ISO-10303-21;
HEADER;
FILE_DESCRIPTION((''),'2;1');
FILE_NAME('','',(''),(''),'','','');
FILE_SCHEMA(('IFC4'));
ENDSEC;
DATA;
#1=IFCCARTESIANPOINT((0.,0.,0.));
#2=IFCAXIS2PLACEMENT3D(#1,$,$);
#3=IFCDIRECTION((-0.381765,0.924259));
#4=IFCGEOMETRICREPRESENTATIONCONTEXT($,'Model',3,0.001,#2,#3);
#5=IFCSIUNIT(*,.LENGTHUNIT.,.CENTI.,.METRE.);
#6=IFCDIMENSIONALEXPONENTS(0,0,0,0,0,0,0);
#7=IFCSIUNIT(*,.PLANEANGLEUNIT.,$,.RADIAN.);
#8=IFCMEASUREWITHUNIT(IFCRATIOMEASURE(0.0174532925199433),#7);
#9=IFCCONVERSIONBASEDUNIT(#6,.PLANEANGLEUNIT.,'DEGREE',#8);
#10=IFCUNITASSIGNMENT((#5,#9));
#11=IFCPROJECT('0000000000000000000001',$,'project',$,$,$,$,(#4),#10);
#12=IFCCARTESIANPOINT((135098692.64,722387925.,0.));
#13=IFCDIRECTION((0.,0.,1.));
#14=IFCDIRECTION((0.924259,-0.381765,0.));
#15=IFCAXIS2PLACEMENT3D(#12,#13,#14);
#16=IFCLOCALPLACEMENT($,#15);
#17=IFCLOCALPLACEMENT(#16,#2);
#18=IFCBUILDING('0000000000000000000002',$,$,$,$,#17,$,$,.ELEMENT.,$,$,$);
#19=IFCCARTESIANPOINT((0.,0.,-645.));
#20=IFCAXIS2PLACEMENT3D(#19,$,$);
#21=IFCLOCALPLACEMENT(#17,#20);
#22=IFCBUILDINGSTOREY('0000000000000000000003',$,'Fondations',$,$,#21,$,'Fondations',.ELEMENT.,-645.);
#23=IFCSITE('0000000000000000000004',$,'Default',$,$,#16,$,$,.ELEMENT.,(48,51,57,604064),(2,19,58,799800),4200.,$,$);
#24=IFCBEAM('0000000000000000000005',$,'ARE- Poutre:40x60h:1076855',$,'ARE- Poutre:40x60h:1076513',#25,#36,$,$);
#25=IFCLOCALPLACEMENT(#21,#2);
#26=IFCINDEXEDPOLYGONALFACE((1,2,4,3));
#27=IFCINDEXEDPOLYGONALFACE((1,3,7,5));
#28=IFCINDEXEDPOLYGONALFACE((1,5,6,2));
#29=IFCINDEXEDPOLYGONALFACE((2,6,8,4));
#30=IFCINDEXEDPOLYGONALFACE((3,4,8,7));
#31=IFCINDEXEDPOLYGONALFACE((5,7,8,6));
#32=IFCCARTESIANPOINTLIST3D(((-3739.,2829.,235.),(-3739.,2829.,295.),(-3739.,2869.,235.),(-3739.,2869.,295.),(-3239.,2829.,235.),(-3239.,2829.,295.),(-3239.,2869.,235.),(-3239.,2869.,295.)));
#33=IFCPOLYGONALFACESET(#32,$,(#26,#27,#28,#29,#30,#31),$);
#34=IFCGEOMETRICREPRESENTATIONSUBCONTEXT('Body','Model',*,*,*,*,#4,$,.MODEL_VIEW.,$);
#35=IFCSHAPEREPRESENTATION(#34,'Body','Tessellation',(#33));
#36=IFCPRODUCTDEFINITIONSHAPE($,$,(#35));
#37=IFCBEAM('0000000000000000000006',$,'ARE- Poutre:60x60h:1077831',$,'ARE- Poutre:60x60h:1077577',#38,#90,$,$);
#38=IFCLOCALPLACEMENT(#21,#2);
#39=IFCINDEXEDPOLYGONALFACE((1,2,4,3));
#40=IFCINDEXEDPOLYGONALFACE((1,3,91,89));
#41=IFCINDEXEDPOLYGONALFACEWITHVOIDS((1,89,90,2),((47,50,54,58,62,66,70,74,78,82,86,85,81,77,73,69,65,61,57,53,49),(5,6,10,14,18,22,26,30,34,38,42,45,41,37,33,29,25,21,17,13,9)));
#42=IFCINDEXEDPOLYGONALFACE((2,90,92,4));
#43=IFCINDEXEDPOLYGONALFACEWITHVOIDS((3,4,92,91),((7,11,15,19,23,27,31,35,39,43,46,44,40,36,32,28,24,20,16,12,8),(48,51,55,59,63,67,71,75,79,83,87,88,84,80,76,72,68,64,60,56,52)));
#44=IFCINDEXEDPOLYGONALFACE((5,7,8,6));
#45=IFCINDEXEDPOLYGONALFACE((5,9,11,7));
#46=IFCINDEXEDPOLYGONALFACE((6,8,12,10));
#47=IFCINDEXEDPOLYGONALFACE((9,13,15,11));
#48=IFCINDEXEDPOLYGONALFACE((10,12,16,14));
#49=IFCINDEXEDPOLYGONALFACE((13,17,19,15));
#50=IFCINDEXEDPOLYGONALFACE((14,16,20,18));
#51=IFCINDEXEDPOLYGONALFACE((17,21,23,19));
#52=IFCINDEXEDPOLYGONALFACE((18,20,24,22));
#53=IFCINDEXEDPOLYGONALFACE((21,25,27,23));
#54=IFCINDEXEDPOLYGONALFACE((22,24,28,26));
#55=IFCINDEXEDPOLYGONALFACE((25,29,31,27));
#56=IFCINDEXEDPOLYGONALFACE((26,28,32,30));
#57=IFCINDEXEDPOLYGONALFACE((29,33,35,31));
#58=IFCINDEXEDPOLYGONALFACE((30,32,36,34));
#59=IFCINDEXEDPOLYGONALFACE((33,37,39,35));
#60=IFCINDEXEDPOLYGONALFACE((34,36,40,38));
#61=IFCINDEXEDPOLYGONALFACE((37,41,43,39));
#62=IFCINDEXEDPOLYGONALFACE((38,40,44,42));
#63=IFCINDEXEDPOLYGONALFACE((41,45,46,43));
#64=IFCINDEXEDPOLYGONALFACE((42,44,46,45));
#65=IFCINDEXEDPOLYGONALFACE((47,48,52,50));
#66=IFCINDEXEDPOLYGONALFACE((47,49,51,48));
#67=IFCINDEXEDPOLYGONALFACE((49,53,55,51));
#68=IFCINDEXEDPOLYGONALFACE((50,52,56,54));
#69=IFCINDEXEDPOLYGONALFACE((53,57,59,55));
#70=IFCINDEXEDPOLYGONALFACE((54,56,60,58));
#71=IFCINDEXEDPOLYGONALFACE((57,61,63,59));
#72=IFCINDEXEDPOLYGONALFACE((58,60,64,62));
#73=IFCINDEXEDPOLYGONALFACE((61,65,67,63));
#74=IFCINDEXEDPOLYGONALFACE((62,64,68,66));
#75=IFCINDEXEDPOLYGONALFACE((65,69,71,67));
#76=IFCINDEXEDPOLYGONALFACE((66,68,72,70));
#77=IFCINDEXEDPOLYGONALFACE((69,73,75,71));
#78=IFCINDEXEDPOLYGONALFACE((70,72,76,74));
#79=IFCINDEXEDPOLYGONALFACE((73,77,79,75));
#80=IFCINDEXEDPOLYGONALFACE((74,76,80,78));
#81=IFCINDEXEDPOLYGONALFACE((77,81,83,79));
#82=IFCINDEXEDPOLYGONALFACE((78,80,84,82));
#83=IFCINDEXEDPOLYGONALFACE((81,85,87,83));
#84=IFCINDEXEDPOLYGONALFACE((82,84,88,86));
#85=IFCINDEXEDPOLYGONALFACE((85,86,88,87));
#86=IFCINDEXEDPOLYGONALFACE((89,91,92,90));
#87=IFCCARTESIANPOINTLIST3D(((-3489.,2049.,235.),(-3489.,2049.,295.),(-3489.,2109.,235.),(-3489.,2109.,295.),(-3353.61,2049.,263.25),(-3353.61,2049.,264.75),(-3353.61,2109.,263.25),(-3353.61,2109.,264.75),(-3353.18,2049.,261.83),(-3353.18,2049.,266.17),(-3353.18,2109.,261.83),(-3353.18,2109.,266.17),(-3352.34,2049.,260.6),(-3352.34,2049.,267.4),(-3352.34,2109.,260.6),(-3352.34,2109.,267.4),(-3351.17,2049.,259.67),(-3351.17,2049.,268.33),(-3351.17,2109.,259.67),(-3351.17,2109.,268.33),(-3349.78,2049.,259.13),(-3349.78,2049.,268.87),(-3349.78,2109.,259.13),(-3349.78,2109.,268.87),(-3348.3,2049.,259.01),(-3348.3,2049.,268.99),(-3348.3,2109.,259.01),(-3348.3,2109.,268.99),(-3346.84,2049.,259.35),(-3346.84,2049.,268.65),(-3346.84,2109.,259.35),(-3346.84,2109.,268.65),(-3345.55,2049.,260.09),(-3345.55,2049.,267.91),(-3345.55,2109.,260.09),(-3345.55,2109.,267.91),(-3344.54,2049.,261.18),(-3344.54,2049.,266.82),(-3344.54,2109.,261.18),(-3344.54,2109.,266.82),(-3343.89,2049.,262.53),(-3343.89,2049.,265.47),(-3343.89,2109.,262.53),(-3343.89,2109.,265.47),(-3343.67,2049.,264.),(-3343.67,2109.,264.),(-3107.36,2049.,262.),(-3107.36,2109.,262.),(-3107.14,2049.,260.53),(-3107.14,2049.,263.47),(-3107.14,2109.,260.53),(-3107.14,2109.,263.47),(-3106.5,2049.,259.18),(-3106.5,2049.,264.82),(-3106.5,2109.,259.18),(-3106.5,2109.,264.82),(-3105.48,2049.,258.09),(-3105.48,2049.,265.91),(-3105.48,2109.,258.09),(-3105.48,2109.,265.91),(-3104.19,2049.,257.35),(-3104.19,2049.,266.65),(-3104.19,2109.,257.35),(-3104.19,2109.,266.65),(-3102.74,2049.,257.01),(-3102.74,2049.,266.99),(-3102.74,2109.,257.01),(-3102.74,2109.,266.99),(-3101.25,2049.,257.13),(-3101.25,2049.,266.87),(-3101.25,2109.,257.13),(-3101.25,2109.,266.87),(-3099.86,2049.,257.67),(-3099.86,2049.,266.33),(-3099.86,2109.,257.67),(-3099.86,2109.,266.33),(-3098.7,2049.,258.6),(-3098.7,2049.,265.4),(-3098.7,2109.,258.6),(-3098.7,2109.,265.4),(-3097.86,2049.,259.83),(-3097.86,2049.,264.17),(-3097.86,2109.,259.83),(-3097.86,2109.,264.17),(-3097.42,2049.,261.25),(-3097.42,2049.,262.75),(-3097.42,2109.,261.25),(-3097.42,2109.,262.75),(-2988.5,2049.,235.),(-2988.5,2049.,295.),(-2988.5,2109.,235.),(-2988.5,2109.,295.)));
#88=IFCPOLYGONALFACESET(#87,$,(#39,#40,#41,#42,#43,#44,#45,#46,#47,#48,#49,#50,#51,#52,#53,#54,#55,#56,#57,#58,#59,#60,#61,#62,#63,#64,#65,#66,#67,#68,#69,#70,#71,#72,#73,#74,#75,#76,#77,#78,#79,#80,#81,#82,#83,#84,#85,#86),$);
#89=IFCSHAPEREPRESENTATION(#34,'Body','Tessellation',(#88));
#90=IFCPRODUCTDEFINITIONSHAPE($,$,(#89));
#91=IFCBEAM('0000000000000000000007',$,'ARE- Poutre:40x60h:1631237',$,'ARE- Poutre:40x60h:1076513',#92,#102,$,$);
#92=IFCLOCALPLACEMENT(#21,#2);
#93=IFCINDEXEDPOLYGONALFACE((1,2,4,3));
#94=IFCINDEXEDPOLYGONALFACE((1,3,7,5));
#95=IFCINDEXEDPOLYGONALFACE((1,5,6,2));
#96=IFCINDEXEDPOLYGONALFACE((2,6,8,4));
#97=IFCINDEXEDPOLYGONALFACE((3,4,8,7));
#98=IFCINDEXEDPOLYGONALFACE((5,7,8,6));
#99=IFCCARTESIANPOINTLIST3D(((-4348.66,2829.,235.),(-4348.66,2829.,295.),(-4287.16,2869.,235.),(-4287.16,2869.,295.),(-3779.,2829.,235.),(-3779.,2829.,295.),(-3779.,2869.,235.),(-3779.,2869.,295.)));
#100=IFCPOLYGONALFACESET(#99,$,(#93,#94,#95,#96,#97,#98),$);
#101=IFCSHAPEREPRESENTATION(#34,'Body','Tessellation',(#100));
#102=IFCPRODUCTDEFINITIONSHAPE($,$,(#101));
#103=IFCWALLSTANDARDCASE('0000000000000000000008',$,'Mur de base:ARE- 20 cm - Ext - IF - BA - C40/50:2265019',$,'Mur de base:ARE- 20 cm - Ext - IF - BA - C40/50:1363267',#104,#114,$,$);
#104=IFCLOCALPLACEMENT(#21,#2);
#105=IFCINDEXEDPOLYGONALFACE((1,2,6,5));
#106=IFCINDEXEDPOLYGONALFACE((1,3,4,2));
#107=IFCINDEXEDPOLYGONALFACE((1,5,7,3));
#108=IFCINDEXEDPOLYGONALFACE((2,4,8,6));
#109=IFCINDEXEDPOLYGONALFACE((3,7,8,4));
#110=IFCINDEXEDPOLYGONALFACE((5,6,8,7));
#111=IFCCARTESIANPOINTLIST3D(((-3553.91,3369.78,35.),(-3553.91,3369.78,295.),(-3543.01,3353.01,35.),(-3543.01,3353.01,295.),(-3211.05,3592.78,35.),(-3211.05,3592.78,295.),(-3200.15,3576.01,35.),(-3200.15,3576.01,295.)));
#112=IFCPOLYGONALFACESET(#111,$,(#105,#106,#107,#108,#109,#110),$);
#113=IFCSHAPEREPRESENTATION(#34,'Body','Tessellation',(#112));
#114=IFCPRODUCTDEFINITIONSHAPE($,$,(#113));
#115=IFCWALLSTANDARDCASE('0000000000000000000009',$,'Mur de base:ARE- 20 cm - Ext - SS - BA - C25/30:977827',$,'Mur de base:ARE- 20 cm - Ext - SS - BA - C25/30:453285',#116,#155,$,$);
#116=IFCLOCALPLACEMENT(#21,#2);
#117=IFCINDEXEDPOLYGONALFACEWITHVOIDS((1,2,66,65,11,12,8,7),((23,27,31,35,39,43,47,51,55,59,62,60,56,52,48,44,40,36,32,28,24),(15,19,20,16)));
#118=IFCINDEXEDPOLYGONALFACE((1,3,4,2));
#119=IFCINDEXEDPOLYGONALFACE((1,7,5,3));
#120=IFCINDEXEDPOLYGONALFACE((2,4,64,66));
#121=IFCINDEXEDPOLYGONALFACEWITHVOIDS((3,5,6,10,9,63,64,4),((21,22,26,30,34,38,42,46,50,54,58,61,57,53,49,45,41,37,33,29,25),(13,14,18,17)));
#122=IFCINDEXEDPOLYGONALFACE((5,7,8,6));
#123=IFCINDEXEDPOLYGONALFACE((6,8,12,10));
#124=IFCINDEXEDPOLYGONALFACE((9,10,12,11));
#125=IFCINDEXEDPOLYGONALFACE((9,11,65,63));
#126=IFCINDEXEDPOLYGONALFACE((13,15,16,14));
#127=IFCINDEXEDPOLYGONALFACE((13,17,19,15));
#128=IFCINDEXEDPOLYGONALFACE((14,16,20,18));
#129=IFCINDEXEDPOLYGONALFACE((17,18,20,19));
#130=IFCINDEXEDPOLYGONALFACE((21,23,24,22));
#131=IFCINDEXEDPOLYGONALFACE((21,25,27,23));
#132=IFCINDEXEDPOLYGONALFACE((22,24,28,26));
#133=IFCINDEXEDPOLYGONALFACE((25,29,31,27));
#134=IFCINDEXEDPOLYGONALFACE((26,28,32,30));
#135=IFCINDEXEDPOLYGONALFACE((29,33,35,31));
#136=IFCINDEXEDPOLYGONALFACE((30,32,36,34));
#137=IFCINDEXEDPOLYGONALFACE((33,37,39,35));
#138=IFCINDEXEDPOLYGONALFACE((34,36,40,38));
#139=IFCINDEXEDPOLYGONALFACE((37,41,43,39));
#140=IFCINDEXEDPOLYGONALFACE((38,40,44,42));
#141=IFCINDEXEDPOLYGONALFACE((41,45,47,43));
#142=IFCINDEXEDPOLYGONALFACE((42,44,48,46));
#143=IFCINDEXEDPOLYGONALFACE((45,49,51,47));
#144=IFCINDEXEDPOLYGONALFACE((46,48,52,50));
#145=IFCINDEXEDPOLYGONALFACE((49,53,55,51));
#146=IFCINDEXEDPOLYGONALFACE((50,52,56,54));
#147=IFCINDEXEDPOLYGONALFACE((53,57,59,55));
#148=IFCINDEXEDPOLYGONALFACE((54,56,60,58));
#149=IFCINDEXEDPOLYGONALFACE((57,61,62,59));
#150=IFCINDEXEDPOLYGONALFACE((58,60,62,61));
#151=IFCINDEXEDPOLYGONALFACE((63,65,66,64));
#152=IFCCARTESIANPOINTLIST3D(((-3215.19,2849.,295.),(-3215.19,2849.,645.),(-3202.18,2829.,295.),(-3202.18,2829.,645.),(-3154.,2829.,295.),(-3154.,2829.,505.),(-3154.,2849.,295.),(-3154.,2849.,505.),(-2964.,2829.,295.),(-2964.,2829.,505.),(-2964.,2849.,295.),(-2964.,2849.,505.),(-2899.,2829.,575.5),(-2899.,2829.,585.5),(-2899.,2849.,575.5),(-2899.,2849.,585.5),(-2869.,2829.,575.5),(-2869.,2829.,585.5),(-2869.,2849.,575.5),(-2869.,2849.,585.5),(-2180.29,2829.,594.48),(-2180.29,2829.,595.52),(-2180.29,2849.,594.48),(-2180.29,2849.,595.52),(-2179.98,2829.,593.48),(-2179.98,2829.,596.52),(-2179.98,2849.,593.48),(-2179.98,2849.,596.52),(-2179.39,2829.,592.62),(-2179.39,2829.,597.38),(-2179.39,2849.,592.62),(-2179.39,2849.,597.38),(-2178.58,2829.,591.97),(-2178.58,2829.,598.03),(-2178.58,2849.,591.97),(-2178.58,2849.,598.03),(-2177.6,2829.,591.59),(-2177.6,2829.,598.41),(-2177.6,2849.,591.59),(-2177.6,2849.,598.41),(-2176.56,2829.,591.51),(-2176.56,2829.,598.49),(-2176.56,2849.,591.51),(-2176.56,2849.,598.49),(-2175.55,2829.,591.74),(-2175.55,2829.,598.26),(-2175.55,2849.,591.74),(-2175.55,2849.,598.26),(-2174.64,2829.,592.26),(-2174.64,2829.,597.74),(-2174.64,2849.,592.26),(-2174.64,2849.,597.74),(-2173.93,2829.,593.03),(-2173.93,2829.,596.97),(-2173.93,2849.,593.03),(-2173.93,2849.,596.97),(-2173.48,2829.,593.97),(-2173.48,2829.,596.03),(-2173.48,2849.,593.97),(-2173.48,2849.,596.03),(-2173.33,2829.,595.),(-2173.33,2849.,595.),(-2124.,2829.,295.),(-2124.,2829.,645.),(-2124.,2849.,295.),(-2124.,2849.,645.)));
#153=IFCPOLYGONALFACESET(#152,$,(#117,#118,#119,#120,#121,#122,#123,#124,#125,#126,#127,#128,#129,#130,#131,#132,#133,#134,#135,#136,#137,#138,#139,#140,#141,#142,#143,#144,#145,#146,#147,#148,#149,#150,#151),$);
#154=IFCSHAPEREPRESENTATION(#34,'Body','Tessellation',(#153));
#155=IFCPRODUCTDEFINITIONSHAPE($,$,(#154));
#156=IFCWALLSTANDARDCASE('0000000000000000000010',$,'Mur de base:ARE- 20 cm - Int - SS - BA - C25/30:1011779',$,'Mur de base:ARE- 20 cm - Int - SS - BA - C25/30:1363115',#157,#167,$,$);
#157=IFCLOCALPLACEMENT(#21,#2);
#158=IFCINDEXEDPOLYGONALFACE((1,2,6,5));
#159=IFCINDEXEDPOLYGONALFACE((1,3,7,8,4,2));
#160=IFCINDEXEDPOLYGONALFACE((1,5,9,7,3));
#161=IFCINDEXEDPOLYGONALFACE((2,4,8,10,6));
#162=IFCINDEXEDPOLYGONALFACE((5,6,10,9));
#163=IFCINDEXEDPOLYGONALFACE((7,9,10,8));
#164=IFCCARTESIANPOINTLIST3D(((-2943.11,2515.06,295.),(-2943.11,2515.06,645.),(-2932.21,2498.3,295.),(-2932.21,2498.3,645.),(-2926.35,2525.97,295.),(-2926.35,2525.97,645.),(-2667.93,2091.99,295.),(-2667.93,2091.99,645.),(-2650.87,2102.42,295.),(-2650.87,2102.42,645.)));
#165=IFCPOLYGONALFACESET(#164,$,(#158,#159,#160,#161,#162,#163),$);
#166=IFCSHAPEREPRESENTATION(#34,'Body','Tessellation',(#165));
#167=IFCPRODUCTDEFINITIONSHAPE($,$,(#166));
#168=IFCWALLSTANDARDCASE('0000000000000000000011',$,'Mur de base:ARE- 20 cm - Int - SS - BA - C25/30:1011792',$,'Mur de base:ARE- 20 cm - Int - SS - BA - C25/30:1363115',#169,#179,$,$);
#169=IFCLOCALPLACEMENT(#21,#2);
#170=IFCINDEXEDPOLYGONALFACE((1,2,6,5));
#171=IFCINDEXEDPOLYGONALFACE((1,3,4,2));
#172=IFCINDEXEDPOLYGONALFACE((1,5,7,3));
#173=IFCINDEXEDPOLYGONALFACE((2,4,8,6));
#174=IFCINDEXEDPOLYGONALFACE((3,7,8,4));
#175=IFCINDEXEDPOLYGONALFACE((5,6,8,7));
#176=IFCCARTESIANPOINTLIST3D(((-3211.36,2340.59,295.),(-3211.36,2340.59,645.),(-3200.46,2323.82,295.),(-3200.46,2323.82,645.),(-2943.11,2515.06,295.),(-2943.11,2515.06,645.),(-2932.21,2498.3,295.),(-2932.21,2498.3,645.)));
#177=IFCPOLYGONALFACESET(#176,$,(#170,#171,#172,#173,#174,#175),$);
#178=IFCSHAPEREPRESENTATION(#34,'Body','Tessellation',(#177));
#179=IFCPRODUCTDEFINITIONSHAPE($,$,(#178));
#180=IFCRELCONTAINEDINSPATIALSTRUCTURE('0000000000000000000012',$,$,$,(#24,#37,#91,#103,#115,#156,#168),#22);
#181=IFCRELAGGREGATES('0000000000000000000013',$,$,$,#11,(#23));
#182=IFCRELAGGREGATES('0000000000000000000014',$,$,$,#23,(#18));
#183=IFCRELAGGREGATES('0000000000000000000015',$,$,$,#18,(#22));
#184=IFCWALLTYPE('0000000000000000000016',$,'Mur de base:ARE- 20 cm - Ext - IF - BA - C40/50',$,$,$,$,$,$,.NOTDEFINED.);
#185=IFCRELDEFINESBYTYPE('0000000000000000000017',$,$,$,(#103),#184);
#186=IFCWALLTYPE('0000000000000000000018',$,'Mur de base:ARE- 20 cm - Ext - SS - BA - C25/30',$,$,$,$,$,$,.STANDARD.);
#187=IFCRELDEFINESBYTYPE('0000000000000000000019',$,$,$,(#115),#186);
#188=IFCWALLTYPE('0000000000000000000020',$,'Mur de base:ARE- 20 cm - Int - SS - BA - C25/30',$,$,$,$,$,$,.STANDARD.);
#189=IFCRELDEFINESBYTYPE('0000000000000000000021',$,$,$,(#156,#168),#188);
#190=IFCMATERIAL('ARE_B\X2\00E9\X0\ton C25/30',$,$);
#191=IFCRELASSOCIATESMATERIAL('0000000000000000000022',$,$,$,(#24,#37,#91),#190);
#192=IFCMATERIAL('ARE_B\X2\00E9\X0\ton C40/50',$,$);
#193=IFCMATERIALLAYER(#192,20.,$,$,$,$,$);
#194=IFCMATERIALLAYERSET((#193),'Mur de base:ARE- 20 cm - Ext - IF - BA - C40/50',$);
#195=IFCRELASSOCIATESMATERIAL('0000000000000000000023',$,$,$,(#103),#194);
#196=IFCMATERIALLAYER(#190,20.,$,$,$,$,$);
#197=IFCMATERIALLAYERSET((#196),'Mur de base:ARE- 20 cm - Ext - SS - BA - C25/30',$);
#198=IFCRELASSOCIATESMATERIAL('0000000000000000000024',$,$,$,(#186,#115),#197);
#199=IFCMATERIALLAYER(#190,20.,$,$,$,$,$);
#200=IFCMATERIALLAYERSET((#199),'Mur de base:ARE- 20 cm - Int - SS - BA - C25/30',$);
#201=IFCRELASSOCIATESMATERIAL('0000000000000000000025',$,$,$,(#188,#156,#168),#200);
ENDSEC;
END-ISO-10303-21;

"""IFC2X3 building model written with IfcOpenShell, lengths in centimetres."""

from ifc_helpers import new_model, entity, si_unit, converted_unit, direction, frame, frame_2d, origin, origin_2d_with_axis, place, context, subcontext, project, spatial, polyline, rectangle, circle, outline, extrude, boolean, clip, halfspace, material, layer, layer_set, layer_usage, type_object, element, save


model = new_model("IFC2X3")

# Units and contexts
model_context = context("Model", 3, precision=0.001, world=origin(), true_north=direction((-0.381765, 0.924259)))
body_context = subcontext(model_context, "Body", "Model", "MODEL_VIEW")
ifc_project = project(units=[si_unit("LENGTHUNIT", "METRE", prefix="CENTI"), converted_unit("PLANEANGLEUNIT", "DEGREE", entity("IfcRatioMeasure", 0.0174532925199433), si_unit("PLANEANGLEUNIT", "RADIAN"), dimensions=[0, 0, 0, 0, 0, 0, 0])], contexts=[model_context])

# Site, building, storey
site_placement = place(None, frame((135098692.64, 722387925.0, 0.0), z_axis=(0.0, 0.0, 1.0), x_axis=(0.924259, -0.381765, 0.0)))
site = spatial("IfcSite", under=ifc_project, at=site_placement, Name="Default", CompositionType="ELEMENT", RefLatitude=(48, 51, 57, 604064), RefLongitude=(2, 19, 58, 799800), RefElevation=4200.0)
building_placement = place(site_placement, origin())
building = spatial("IfcBuilding", under=site, at=building_placement, CompositionType="ELEMENT")
storey_placement = place(building_placement, frame((0.0, 0.0, -645.0)))
storey = spatial("IfcBuildingStorey", under=building, at=storey_placement, Name="Fondations", LongName="Fondations", CompositionType="ELEMENT", Elevation=-645.0)

# Beams
ifc_material_1 = material(Name="ARE_Béton C25/30")
beam_1_placement = place(storey_placement, frame((-3739.0, 2849.0, 295.0)))
element("IfcBeam", 1, at=beam_1_placement, inside=storey, material=ifc_material_1, Name="ARE- Poutre:40x60h:1076855", ObjectType="ARE- Poutre:40x60h:1076513", context=body_context, shape_type="SweptSolid", body=[
    extrude(rectangle(XDim=60.0, YDim=40.0, at=frame_2d((0.0, 0.0), x_axis=(1.0, 0.0))), frame((0.0, 0.0, -30.0), z_axis=(1.0, 0.0, 0.0), x_axis=(0.0, 0.0, -1.0)), (0.0, 0.0, 1.0), 500.0),
])
beam_2_placement = place(storey_placement, frame((-3509.0, 2079.0, 295.0)))
element("IfcBeam", 2, at=beam_2_placement, inside=storey, material=ifc_material_1, Name="ARE- Poutre:60x60h:1077831", ObjectType="ARE- Poutre:60x60h:1077577", context=body_context, shape_type="CSG", body=[
    boolean("DIFFERENCE", boolean("DIFFERENCE", extrude(rectangle(XDim=60.0, YDim=60.0, at=frame_2d((0.0, 0.0), x_axis=(0.0, 1.0))), frame((20.0, 0.0, -30.0), z_axis=(1.0, 0.0, 0.0), x_axis=(0.0, 1.0, 0.0)), (0.0, 0.0, 1.0), 500.5), extrude(circle(Radius=5.0, at=frame_2d((0.0, 0.0), x_axis=(1.0, 0.0))), frame((160.33, 30.0, -31.0), z_axis=(0.0, -1.0, 0.0), x_axis=(1.0, 0.0, 0.0)), (0.0, 0.0, 1.0), 60.0)), extrude(circle(Radius=5.0, at=frame_2d((0.0, 0.0), x_axis=(1.0, 0.0))), frame((406.64, 30.0, -33.0), z_axis=(0.0, -1.0, 0.0), x_axis=(-1.0, 0.0, 0.0)), (0.0, 0.0, 1.0), 60.0)),
])
beam_3_placement = place(storey_placement, frame((-3779.0, 2849.0, 295.0), z_axis=(0.0, 0.0, 1.0), x_axis=(-1.0, 0.0, 0.0)))
element("IfcBeam", 3, at=beam_3_placement, inside=storey, material=ifc_material_1, Name="ARE- Poutre:40x60h:1631237", ObjectType="ARE- Poutre:40x60h:1076513", context=body_context, shape_type="Clipping", body=[
    clip(extrude(rectangle(XDim=60.0, YDim=40.0, at=frame_2d((0.0, 0.0), x_axis=(1.0, 0.0))), frame((0.0, 0.0, -30.0), z_axis=(1.0, 0.0, 0.0), x_axis=(0.0, 0.0, -1.0)), (0.0, 0.0, 1.0), 569.66), halfspace(frame((2420.15, 1223.6, -260.0), z_axis=(0.545236, -0.838282, 0.0), x_axis=(-0.838282, -0.545236, 0.0)), False)),
])

# Wall
ifc_material_2 = material(Name="ARE_Béton C40/50")
ifc_layer_1 = layer(ifc_material_2, 20.0)
ifc_layer_set_1 = layer_set([ifc_layer_1], Name="Mur de base:ARE- 20 cm - Ext - IF - BA - C40/50")
ifc_layer_usage_1 = layer_usage(ifc_layer_set_1, "AXIS2", "NEGATIVE", 10.0)
wall_type_1 = type_object("IfcWallType", Name="Mur de base:ARE- 20 cm - Ext - IF - BA - C40/50", PredefinedType="NOTDEFINED")
wall_1_placement = place(storey_placement, frame((-3548.46, 3361.39, 35.0), z_axis=(0.0, 0.0, 1.0), x_axis=(0.838282, 0.545236, 0.0)))
element("IfcWallStandardCase", 4, at=wall_1_placement, inside=storey, type_object=wall_type_1, material=ifc_layer_usage_1, Name="Mur de base:ARE- 20 cm - Ext - IF - BA - C40/50:2265019", ObjectType="Mur de base:ARE- 20 cm - Ext - IF - BA - C40/50:1363267", context=body_context, shape_type="SweptSolid", body=[
    extrude(rectangle(XDim=409.0, YDim=20.0, at=frame_2d((204.5, 0.0), x_axis=(-1.0, 0.0))), origin(), (0.0, 0.0, 1.0), 260.0),
])

# Wall, openings
ifc_layer_2 = layer(ifc_material_1, 20.0)
ifc_layer_set_2 = layer_set([ifc_layer_2], Name="Mur de base:ARE- 20 cm - Ext - SS - BA - C25/30")
ifc_layer_usage_2 = layer_usage(ifc_layer_set_2, "AXIS2", "NEGATIVE", 10.0)
wall_type_2 = type_object("IfcWallType", Name="Mur de base:ARE- 20 cm - Ext - SS - BA - C25/30", PredefinedType="STANDARD", material=ifc_layer_set_2)
wall_2_placement = place(storey_placement, frame((-3215.19, 2839.0, 295.0)))
wall_2 = element("IfcWallStandardCase", 5, at=wall_2_placement, inside=storey, type_object=wall_type_2, material=ifc_layer_usage_2, Name="Mur de base:ARE- 20 cm - Ext - SS - BA - C25/30:977827", ObjectType="Mur de base:ARE- 20 cm - Ext - SS - BA - C25/30:453285", context=body_context, shape_type="SweptSolid", body=[
    extrude(outline(polyline([(13.01, -10.0), (16.19, -10.0), (416.19, -10.0), (456.19, -10.0), (1051.19, -10.0), (1091.19, -10.0), (1091.19, 10.0), (1071.19, 10.0), (0.0, 10.0), (13.01, -10.0)])), origin(), (0.0, 0.0, 1.0), 350.0),
])
opening_1_placement = place(wall_2_placement, origin())
element("IfcOpeningElement", 6, at=opening_1_placement, cuts=wall_2, ObjectType="Opening", context=body_context, shape_type="SweptSolid", body=[
    extrude(rectangle(XDim=10.0, YDim=30.0, at=frame_2d((0.0, 0.0), x_axis=(1.0, 0.0))), frame((331.19, -10.0, 285.5), z_axis=(0.0, 1.0, 0.0), x_axis=(0.0, 0.0, -1.0)), (0.0, 0.0, 1.0), 20.0),
])
opening_2_placement = place(wall_2_placement, origin())
element("IfcOpeningElement", 7, at=opening_2_placement, cuts=wall_2, ObjectType="Opening", context=body_context, shape_type="SweptSolid", body=[
    extrude(circle(Radius=3.5, at=frame_2d((0.0, 0.0), x_axis=(1.0, 0.0))), frame((1038.36, -10.0, 300.0), z_axis=(0.0, 1.0, 0.0), x_axis=(1.0, 0.0, 0.0)), (0.0, 0.0, 1.0), 20.0),
])
opening_3_placement = place(wall_2_placement, frame((3215.19, -2839.0, -295.0)))
element("IfcOpeningElement", 8, at=opening_3_placement, cuts=wall_2, ObjectType="Opening", context=body_context, shape_type="SweptSolid", body=[
    extrude(rectangle(XDim=210.0, YDim=190.0, at=origin_2d_with_axis()), frame((-3059.0, 2696.6, 400.0), z_axis=(0.0, 1.0, 0.0), x_axis=(0.0, 0.0, -1.0)), (0.0, 0.0, 1.0), 304.8),
])

# Walls
ifc_layer_3 = layer(ifc_material_1, 20.0)
ifc_layer_set_3 = layer_set([ifc_layer_3], Name="Mur de base:ARE- 20 cm - Int - SS - BA - C25/30")
ifc_layer_usage_3 = layer_usage(ifc_layer_set_3, "AXIS2", "NEGATIVE", 10.0)
wall_type_3 = type_object("IfcWallType", Name="Mur de base:ARE- 20 cm - Int - SS - BA - C25/30", PredefinedType="STANDARD", material=ifc_layer_set_3)
wall_3_placement = place(storey_placement, frame((-2934.73, 2520.52, 295.0), z_axis=(0.0, 0.0, 1.0), x_axis=(0.545236, -0.838282, 0.0)))
element("IfcWallStandardCase", 9, at=wall_3_placement, inside=storey, type_object=wall_type_3, material=ifc_layer_usage_3, Name="Mur de base:ARE- 20 cm - Int - SS - BA - C25/30:1011779", ObjectType="Mur de base:ARE- 20 cm - Int - SS - BA - C25/30:1363115", context=body_context, shape_type="SweptSolid", body=[
    extrude(outline(polyline([(504.69, -10.0), (505.25, 10.0), (0.0, 10.0), (0.0, -10.0), (20.0, -10.0), (504.69, -10.0)])), origin(), (0.0, 0.0, 1.0), 350.0),
])
ifc_layer_usage_4 = layer_usage(ifc_layer_set_3, "AXIS2", "NEGATIVE", 10.0)
wall_4_placement = place(storey_placement, frame((-3205.91, 2332.2, 295.0), z_axis=(0.0, 0.0, 1.0), x_axis=(0.838282, 0.545236, 0.0)))
element("IfcWallStandardCase", 10, at=wall_4_placement, inside=storey, type_object=wall_type_3, material=ifc_layer_usage_4, Name="Mur de base:ARE- 20 cm - Int - SS - BA - C25/30:1011792", ObjectType="Mur de base:ARE- 20 cm - Int - SS - BA - C25/30:1363115", context=body_context, shape_type="SweptSolid", body=[
    extrude(rectangle(XDim=320.0, YDim=20.0, at=frame_2d((160.0, 0.0), x_axis=(-1.0, 0.0))), origin(), (0.0, 0.0, 1.0), 350.0),
])

save(model, "model.ifc")
